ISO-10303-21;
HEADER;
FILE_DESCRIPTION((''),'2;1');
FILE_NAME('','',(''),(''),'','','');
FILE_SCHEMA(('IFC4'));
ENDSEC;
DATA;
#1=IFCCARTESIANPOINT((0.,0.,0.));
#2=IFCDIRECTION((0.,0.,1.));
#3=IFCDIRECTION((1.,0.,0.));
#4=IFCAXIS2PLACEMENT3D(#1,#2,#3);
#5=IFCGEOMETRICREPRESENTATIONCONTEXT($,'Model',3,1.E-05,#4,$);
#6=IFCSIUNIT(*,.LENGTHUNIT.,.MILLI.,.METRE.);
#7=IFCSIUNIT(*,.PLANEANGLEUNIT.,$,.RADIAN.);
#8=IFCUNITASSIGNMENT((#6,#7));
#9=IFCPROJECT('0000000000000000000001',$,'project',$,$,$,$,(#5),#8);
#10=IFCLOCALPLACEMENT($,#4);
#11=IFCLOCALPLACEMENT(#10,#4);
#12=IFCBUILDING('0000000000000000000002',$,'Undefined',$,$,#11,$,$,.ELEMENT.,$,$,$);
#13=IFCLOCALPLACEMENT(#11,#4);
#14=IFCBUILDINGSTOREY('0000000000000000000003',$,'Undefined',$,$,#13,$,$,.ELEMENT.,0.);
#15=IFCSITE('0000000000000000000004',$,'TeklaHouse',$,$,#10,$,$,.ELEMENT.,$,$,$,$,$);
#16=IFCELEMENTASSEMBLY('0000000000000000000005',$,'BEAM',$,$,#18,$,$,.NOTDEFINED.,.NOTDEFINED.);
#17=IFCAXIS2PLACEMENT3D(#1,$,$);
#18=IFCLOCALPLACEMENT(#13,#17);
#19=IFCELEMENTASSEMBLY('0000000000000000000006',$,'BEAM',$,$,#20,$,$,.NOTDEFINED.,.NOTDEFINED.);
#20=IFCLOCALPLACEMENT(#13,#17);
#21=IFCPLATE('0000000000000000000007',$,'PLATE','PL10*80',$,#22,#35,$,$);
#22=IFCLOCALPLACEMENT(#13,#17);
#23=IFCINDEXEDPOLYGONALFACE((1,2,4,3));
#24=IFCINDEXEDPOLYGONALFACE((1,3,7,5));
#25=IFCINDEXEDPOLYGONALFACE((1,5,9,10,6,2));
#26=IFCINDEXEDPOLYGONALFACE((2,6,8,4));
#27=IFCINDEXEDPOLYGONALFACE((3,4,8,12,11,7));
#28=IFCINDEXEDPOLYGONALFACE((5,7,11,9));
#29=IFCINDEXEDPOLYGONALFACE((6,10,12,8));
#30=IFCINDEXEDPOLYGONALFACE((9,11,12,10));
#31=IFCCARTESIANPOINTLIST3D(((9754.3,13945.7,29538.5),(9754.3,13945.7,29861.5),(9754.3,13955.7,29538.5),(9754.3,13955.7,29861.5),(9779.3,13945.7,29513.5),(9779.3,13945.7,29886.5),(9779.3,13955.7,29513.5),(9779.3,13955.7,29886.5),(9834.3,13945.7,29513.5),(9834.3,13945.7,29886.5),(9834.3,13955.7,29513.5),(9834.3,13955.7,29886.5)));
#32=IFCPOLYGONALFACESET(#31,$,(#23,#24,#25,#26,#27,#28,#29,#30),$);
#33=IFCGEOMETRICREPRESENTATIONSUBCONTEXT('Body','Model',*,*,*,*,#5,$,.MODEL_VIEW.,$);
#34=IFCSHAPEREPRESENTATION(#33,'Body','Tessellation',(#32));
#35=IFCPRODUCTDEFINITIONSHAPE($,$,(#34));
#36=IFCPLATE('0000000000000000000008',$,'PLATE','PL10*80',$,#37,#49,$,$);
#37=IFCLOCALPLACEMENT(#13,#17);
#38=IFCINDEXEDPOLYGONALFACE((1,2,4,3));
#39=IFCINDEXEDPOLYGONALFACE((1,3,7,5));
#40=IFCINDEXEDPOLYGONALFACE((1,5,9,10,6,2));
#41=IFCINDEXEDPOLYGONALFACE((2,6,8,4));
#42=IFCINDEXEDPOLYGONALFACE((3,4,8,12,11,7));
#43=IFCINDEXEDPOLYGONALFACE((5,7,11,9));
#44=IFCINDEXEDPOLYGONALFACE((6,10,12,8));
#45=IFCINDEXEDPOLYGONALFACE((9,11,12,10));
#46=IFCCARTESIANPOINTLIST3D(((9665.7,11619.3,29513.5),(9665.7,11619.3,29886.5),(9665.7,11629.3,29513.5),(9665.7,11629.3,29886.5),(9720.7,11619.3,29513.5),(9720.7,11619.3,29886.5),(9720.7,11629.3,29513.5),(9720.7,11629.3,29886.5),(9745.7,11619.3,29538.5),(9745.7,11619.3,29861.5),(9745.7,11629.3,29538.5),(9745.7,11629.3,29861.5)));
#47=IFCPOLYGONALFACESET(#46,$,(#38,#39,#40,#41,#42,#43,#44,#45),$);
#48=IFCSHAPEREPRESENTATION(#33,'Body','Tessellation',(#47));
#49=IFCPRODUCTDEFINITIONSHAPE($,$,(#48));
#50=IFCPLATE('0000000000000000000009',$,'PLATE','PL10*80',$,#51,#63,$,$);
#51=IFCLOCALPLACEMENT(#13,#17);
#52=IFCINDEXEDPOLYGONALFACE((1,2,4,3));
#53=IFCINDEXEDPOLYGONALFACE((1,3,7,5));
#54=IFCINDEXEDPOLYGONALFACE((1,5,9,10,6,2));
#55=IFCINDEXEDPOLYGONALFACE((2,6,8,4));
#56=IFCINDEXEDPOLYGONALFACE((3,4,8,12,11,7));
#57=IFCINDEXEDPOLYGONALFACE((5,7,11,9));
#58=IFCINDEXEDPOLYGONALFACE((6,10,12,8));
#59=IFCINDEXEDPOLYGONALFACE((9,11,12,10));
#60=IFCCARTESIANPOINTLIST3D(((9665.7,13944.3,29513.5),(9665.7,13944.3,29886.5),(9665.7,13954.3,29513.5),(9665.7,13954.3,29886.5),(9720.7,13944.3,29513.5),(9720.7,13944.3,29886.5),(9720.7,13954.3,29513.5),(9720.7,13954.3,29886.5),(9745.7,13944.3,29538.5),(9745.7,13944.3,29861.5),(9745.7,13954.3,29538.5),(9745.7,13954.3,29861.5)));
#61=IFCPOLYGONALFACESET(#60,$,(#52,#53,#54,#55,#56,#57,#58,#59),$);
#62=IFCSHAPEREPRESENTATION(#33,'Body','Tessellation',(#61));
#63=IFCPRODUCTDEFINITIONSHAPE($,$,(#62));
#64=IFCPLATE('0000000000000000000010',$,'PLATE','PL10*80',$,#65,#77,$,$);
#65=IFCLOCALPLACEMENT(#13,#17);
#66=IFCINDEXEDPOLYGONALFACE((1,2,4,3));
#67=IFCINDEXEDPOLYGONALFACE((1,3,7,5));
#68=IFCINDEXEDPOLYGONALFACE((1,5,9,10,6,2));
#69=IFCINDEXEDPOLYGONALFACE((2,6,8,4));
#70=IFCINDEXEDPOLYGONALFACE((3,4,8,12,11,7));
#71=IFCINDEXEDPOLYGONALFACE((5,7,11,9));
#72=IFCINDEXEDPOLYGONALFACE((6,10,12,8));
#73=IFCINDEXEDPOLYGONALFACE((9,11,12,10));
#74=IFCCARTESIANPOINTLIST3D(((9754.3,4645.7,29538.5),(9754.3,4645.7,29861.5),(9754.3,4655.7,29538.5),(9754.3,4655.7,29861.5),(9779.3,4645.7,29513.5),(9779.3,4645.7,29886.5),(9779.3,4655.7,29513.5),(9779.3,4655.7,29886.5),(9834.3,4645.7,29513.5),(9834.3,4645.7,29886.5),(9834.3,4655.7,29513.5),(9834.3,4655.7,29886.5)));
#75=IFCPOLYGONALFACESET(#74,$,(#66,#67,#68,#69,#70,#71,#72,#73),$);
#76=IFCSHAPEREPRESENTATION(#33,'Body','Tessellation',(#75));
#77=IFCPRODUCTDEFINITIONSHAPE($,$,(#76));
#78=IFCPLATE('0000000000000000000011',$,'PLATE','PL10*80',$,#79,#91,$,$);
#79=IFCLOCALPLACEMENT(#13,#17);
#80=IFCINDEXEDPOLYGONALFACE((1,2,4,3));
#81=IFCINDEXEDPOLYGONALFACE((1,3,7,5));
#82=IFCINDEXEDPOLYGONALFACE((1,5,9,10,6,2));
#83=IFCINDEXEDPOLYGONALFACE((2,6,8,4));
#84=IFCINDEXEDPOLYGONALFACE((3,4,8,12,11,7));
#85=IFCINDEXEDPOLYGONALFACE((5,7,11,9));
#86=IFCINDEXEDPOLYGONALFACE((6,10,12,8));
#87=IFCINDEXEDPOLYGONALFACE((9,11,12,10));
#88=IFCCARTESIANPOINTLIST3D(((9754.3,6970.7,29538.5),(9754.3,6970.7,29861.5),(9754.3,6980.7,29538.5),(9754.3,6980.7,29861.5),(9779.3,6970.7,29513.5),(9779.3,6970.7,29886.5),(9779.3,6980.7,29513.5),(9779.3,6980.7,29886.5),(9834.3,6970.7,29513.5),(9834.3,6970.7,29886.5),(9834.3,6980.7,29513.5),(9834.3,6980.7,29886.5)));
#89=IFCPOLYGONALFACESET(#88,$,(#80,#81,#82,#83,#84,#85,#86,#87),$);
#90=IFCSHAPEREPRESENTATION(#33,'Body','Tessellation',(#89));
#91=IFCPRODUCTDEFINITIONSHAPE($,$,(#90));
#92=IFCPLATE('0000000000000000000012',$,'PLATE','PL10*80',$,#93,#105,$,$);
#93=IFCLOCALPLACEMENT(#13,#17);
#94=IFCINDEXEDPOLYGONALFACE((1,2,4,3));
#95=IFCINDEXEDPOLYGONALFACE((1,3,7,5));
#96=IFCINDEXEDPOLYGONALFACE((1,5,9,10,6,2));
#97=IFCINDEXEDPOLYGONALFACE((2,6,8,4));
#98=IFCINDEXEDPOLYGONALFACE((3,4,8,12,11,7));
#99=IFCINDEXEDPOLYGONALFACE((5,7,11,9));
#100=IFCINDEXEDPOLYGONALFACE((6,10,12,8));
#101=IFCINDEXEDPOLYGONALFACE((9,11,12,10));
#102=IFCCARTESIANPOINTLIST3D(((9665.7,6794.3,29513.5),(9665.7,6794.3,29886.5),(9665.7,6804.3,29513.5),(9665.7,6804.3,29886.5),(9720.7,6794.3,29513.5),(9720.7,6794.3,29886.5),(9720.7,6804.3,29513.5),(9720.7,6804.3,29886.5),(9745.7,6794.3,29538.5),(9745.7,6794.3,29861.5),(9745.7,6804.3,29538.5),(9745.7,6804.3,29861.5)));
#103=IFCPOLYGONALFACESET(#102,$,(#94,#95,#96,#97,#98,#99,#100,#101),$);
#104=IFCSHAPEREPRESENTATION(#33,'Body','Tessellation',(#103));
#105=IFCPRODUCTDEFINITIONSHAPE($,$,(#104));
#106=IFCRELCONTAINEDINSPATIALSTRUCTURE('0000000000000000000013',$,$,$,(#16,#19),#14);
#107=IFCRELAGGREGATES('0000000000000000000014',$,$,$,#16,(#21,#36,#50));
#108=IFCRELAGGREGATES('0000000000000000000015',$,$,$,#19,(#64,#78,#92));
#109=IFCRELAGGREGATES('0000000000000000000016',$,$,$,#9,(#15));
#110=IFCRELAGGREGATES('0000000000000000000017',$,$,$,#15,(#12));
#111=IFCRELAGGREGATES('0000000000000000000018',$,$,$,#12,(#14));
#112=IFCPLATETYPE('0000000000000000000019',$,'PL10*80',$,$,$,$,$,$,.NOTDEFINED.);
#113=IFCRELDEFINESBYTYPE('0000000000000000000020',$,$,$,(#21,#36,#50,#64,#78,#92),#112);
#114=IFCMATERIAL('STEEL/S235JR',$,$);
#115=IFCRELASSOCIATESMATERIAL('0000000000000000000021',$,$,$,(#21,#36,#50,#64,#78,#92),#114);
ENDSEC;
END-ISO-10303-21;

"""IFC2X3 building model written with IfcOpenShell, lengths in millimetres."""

from ifc_helpers import new_model, si_unit, frame, origin_with_axes, place, context, subcontext, project, spatial, polyline, outline, extrude, material, type_object, element, aggregate, save


model = new_model("IFC2X3")

# Units and contexts
model_context = context("Model", 3, precision=1e-05, world=origin_with_axes())
body_context = subcontext(model_context, "Body", "Model", "MODEL_VIEW")
ifc_project = project(units=[si_unit("LENGTHUNIT", "METRE", prefix="MILLI"), si_unit("PLANEANGLEUNIT", "RADIAN")], contexts=[model_context])

# Site, building, storey
site_placement = place(None, origin_with_axes())
site = spatial("IfcSite", under=ifc_project, at=site_placement, Name="TeklaHouse", CompositionType="ELEMENT")
building_placement = place(site_placement, origin_with_axes())
building = spatial("IfcBuilding", under=site, at=building_placement, Name="Undefined", CompositionType="ELEMENT")
storey_placement = place(building_placement, origin_with_axes())
storey = spatial("IfcBuildingStorey", under=building, at=storey_placement, Name="Undefined", CompositionType="ELEMENT", Elevation=0.0)

# Element assemblies
ifc_material_1 = material(Name="STEEL/S235JR")
assembly_1_placement = place(storey_placement, origin_with_axes())
assembly_1 = element("IfcElementAssembly", 1, at=assembly_1_placement, inside=storey, Name="BEAM", AssemblyPlace="NOTDEFINED", PredefinedType="NOTDEFINED")
assembly_2_placement = place(storey_placement, origin_with_axes())
assembly_2 = element("IfcElementAssembly", 2, at=assembly_2_placement, inside=storey, Name="BEAM", AssemblyPlace="NOTDEFINED", PredefinedType="NOTDEFINED")

# Plates
plate_type = type_object("IfcPlateType", Name="PL10*80", PredefinedType="NOTDEFINED")
plate_1_placement = place(assembly_1_placement, frame((9754.3, 13950.7, 29513.5), z_axis=(0.0, -1.0, 0.0), x_axis=(1.0, 0.0, 0.0)))
plate_1 = element("IfcPlate", 3, at=plate_1_placement, type_object=plate_type, material=ifc_material_1, Name="PLATE", Description="PL10*80", context=body_context, shape_type="SweptSolid", body=[
    extrude(outline(polyline([(0.0, 25.0), (25.0, 0.0), (80.0, 0.0), (80.0, 373.0), (25.0, 373.0), (0.0, 348.0), (0.0, 25.0)])), frame((0.0, 0.0, -5.0), z_axis=(0.0, 0.0, 1.0), x_axis=(1.0, 0.0, 0.0)), (0.0, 0.0, 1.0), 10.0),
])
plate_2_placement = place(assembly_1_placement, frame((9745.7, 11624.3, 29513.5), z_axis=(0.0, 1.0, 0.0), x_axis=(-1.0, 0.0, 0.0)))
plate_2 = element("IfcPlate", 4, at=plate_2_placement, type_object=plate_type, material=ifc_material_1, Name="PLATE", Description="PL10*80", context=body_context, shape_type="SweptSolid", body=[
    extrude(outline(polyline([(0.0, 25.0), (25.0, 0.0), (80.0, 0.0), (80.0, 373.0), (25.0, 373.0), (0.0, 348.0), (0.0, 25.0)])), frame((0.0, 0.0, -5.0), z_axis=(0.0, 0.0, 1.0), x_axis=(1.0, 0.0, 0.0)), (0.0, 0.0, 1.0), 10.0),
])
plate_3_placement = place(assembly_1_placement, frame((9745.7, 13949.3, 29513.5), z_axis=(0.0, 1.0, 0.0), x_axis=(-1.0, 0.0, 0.0)))
plate_3 = element("IfcPlate", 5, at=plate_3_placement, type_object=plate_type, material=ifc_material_1, Name="PLATE", Description="PL10*80", context=body_context, shape_type="SweptSolid", body=[
    extrude(outline(polyline([(0.0, 25.0), (25.0, 0.0), (80.0, 0.0), (80.0, 373.0), (25.0, 373.0), (0.0, 348.0), (0.0, 25.0)])), frame((0.0, 0.0, -5.0), z_axis=(0.0, 0.0, 1.0), x_axis=(1.0, 0.0, 0.0)), (0.0, 0.0, 1.0), 10.0),
])
aggregate(assembly_1, [plate_1, plate_2, plate_3])
plate_4_placement = place(assembly_2_placement, frame((9754.3, 4650.7, 29513.5), z_axis=(0.0, -1.0, 0.0), x_axis=(1.0, 0.0, 0.0)))
plate_4 = element("IfcPlate", 6, at=plate_4_placement, type_object=plate_type, material=ifc_material_1, Name="PLATE", Description="PL10*80", context=body_context, shape_type="SweptSolid", body=[
    extrude(outline(polyline([(0.0, 25.0), (25.0, 0.0), (80.0, 0.0), (80.0, 373.0), (25.0, 373.0), (0.0, 348.0), (0.0, 25.0)])), frame((0.0, 0.0, -5.0), z_axis=(0.0, 0.0, 1.0), x_axis=(1.0, 0.0, 0.0)), (0.0, 0.0, 1.0), 10.0),
])
plate_5_placement = place(assembly_2_placement, frame((9754.3, 6975.7, 29513.5), z_axis=(0.0, -1.0, 0.0), x_axis=(1.0, 0.0, 0.0)))
plate_5 = element("IfcPlate", 7, at=plate_5_placement, type_object=plate_type, material=ifc_material_1, Name="PLATE", Description="PL10*80", context=body_context, shape_type="SweptSolid", body=[
    extrude(outline(polyline([(0.0, 25.0), (25.0, 0.0), (80.0, 0.0), (80.0, 373.0), (25.0, 373.0), (0.0, 348.0), (0.0, 25.0)])), frame((0.0, 0.0, -5.0), z_axis=(0.0, 0.0, 1.0), x_axis=(1.0, 0.0, 0.0)), (0.0, 0.0, 1.0), 10.0),
])
plate_6_placement = place(assembly_2_placement, frame((9745.7, 6799.3, 29513.5), z_axis=(0.0, 1.0, 0.0), x_axis=(-1.0, 0.0, 0.0)))
plate_6 = element("IfcPlate", 8, at=plate_6_placement, type_object=plate_type, material=ifc_material_1, Name="PLATE", Description="PL10*80", context=body_context, shape_type="SweptSolid", body=[
    extrude(outline(polyline([(0.0, 25.0), (25.0, 0.0), (80.0, 0.0), (80.0, 373.0), (25.0, 373.0), (0.0, 348.0), (0.0, 25.0)])), frame((0.0, 0.0, -5.0), z_axis=(0.0, 0.0, 1.0), x_axis=(1.0, 0.0, 0.0)), (0.0, 0.0, 1.0), 10.0),
])
aggregate(assembly_2, [plate_4, plate_5, plate_6])

save(model, "model.ifc")
